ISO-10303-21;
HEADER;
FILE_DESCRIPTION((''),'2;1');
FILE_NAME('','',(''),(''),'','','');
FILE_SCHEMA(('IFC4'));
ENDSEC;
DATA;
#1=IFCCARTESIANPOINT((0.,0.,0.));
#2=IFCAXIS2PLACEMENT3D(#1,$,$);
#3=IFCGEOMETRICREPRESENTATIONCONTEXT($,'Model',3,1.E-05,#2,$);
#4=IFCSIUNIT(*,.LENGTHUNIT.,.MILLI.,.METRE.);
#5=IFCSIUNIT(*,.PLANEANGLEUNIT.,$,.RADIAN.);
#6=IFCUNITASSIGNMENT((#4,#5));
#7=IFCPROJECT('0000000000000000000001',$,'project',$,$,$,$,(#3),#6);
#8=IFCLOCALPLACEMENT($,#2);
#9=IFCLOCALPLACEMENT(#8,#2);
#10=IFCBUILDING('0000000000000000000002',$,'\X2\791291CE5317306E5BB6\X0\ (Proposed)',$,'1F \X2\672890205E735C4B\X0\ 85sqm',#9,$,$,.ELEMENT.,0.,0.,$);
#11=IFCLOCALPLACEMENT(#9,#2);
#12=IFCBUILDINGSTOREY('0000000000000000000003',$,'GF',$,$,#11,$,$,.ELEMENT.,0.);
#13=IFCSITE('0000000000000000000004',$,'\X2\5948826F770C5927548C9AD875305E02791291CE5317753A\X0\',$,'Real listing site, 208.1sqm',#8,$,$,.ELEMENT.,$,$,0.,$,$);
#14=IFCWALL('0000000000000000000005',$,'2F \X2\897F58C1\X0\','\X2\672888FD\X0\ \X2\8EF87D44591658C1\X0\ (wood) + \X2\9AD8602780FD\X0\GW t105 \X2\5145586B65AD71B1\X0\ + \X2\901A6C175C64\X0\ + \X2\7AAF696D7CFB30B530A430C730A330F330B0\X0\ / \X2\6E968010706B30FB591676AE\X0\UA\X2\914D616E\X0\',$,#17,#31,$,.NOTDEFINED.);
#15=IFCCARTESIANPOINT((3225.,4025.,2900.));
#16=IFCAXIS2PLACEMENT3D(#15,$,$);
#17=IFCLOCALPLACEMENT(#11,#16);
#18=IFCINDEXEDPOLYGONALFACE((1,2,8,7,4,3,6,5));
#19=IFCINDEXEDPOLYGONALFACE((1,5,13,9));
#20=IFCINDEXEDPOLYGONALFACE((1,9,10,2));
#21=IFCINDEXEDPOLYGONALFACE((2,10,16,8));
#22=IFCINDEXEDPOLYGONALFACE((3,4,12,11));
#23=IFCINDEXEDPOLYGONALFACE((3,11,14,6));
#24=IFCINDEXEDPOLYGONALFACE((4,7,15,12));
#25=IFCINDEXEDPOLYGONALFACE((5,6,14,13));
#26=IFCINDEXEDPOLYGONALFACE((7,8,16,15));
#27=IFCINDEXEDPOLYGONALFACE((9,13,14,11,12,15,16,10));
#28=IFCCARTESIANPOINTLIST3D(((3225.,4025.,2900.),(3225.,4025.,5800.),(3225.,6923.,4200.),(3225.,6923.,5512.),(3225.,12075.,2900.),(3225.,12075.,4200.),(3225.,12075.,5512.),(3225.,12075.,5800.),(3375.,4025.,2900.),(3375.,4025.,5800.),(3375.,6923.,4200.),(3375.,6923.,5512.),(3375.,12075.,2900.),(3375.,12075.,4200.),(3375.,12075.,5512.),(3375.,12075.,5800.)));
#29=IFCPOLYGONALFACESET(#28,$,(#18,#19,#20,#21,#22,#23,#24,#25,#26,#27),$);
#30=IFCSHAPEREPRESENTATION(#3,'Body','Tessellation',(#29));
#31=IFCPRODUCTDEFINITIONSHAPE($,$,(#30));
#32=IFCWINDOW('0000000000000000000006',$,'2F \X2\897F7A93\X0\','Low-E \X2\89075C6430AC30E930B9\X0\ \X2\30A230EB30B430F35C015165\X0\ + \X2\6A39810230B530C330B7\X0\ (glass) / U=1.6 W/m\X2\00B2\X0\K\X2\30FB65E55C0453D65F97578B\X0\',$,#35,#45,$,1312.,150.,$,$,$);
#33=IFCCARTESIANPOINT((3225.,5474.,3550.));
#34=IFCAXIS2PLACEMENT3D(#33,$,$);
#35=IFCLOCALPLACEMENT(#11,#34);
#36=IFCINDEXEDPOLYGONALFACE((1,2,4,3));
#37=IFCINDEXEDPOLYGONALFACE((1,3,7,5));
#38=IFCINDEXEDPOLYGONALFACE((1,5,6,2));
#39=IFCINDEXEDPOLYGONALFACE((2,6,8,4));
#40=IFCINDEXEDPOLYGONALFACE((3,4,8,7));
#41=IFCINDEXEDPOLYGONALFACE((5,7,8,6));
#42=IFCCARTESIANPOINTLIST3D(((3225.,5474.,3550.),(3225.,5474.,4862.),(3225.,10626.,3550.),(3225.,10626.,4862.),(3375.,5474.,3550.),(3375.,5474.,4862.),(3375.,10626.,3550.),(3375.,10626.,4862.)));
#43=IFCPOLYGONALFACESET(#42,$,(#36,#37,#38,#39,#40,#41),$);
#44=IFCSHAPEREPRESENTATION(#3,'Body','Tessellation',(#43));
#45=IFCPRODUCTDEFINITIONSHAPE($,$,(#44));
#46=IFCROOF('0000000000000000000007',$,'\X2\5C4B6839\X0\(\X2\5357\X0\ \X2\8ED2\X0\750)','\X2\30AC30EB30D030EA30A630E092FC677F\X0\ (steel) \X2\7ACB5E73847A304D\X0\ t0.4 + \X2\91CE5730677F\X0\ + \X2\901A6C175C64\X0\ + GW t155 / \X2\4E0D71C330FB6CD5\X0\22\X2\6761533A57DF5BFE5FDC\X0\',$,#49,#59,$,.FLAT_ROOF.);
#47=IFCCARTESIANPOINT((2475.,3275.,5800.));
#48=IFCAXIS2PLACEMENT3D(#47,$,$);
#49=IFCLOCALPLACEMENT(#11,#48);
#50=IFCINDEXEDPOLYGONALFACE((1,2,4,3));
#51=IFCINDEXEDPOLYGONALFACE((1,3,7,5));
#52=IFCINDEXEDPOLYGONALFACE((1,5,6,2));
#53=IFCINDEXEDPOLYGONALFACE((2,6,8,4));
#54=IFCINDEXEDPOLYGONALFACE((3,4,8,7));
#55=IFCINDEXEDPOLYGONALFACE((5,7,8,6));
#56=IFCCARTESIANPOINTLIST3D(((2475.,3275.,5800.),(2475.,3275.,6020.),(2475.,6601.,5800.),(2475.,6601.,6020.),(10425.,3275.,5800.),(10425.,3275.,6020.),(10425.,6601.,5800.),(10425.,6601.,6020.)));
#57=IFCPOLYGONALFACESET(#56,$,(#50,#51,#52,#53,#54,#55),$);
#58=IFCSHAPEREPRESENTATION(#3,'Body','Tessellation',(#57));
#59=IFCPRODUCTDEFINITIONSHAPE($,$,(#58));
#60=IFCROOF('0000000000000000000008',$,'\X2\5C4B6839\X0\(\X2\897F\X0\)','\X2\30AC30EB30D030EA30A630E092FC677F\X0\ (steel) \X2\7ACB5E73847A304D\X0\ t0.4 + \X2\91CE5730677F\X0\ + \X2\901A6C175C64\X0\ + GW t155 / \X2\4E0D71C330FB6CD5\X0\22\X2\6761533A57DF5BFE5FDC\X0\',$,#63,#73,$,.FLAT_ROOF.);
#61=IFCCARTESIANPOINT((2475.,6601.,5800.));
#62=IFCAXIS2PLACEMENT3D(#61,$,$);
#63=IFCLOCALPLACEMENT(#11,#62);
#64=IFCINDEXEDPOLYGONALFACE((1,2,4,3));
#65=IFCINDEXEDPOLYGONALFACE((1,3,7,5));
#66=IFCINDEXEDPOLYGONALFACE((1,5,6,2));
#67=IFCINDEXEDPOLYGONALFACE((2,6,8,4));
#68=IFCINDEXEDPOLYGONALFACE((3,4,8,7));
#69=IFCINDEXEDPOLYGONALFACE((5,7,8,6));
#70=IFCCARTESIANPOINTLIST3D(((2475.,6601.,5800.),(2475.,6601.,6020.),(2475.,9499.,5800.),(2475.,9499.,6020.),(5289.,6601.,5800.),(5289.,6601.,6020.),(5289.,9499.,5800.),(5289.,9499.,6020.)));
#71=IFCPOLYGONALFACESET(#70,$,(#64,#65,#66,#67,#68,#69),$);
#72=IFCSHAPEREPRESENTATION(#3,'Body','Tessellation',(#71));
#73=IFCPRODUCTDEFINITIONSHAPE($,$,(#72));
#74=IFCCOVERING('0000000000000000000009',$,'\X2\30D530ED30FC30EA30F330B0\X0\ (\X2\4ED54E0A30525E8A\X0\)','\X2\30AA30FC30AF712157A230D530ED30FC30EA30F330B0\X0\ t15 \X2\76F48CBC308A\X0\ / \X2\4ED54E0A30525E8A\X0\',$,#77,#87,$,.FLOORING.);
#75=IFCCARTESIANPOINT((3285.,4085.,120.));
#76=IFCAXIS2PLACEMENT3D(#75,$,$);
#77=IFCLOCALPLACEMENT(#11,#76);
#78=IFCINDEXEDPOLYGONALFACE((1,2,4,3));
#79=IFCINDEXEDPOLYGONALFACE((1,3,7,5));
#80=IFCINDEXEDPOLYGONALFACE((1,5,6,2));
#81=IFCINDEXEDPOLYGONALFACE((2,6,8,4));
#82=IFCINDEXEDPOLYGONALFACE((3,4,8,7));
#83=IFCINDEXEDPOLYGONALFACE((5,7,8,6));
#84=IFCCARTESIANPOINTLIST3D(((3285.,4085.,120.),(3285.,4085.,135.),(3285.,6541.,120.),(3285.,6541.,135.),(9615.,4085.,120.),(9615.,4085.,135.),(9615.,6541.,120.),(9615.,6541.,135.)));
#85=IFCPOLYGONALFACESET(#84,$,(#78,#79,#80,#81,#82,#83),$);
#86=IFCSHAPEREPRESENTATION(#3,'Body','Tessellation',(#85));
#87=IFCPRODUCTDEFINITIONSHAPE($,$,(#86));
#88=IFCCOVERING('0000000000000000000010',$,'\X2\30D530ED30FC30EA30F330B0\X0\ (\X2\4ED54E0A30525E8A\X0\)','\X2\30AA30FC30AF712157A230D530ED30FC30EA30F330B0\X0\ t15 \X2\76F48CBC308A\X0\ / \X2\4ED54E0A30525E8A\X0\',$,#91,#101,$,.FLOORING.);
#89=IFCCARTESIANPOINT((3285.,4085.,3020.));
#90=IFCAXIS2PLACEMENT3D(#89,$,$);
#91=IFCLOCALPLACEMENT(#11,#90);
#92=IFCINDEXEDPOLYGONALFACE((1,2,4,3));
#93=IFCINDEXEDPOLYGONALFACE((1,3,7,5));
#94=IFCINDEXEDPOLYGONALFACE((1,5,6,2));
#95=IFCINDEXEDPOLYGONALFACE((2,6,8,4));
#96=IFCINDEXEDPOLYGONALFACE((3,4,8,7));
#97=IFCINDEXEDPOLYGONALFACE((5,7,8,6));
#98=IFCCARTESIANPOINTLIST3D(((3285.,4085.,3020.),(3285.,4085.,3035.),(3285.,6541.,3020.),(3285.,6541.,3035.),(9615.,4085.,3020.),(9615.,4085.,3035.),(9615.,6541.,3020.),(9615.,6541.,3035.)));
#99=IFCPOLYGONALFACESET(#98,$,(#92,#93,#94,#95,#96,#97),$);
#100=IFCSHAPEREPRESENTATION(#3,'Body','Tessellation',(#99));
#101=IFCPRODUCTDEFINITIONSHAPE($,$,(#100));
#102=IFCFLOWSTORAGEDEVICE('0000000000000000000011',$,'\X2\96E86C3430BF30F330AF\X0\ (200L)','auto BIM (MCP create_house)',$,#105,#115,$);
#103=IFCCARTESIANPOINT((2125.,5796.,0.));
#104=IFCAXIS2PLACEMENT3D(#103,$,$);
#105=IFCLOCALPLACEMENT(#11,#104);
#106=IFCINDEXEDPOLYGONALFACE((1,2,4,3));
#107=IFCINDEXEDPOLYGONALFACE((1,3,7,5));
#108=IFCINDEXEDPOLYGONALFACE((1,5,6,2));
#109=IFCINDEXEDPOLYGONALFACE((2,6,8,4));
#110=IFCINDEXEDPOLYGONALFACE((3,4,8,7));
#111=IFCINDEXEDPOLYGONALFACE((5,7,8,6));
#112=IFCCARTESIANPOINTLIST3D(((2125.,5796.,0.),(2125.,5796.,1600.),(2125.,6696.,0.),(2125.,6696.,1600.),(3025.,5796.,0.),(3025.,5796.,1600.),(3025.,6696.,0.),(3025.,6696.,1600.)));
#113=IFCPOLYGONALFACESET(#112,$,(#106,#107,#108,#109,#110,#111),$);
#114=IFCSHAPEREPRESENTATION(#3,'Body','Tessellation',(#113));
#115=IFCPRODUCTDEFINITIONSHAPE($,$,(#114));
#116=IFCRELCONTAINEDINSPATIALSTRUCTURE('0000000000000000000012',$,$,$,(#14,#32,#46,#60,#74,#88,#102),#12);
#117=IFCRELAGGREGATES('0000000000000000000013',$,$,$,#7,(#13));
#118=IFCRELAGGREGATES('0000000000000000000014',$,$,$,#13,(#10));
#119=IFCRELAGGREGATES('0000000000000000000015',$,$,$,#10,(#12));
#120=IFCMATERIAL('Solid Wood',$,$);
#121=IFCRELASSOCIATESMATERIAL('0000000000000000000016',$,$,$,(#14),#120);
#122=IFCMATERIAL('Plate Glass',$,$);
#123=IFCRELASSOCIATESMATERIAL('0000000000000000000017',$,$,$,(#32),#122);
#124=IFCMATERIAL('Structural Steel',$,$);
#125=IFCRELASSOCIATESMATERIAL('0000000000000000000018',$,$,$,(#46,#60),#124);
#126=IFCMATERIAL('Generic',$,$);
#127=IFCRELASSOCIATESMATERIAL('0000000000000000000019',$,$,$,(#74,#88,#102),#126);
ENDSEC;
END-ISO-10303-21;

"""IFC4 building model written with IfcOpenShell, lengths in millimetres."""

from ifc_helpers import new_model, si_unit, frame, frame_2d, origin, place, context, project, spatial, rectangle, extrude, material, element, fill, save


model = new_model("IFC4")

# Units and contexts
model_context = context("Model", 3, precision=1e-05, world=origin())
ifc_project = project(units=[si_unit("LENGTHUNIT", "METRE", prefix="MILLI"), si_unit("PLANEANGLEUNIT", "RADIAN")], contexts=[model_context])

# Site, building, storey
site_placement = place(None, origin())
site = spatial("IfcSite", under=ifc_project, at=site_placement, Name="奈良県大和高田市礒野北町", ObjectType="Real listing site, 208.1sqm", CompositionType="ELEMENT", RefElevation=0.0)
building_placement = place(site_placement, origin())
building = spatial("IfcBuilding", under=site, at=building_placement, Name="礒野北の家 (Proposed)", ObjectType="1F 木造平屋 85sqm", CompositionType="ELEMENT", ElevationOfRefHeight=0.0, ElevationOfTerrain=0.0)
storey_placement = place(building_placement, origin())
storey = spatial("IfcBuildingStorey", under=building, at=storey_placement, Name="GF", CompositionType="ELEMENT", Elevation=0.0)

# Shared definitions
ifc_material_1 = material(Name="Solid Wood")
ifc_material_2 = material(Name="Generic")

# Shared definitions
ifc_material_3 = material(Name="Plate Glass")

# Wall, opening, window
wall_1_placement = place(storey_placement, frame((3225.0, 4025.0, 2900.0)))
wall_1 = element("IfcWall", 1, at=wall_1_placement, inside=storey, material=ifc_material_1, Name="2F 西壁", Description="木製 軸組外壁 (wood) + 高性能GW t105 充填断熱 + 通気層 + 窯業系サイディング / 準耐火・外皮UA配慮", PredefinedType="NOTDEFINED", context=model_context, shape_type="SweptSolid", body=[
    extrude(rectangle(XDim=150.0, YDim=8050.0, at=frame_2d((75.0, 4025.0))), frame((3225.0, 4025.0, 2900.0)), (0.0, 0.0, 1.0), 2900.0),
])
opening_1_placement = place(storey_placement, frame((3225.0, 5474.0, 3550.0)))
opening_1 = element("IfcOpeningElement", 2, at=opening_1_placement, cuts=wall_1, PredefinedType="NOTDEFINED", context=model_context, shape_type="SweptSolid", body=[
    extrude(rectangle(XDim=150.0, YDim=5152.0, at=frame_2d((75.0, 2576.0))), frame((3225.0, 5474.0, 3550.0)), (0.0, 0.0, 1.0), 1312.0),
])
window_1_placement = place(storey_placement, frame((3225.0, 5474.0, 3550.0)))
window_1 = element("IfcWindow", 3, at=window_1_placement, inside=storey, material=ifc_material_3, Name="2F 西窓", Description="Low-E 複層ガラス アルゴン封入 + 樹脂サッシ (glass) / U=1.6 W/m²K・日射取得型", OverallHeight=1312.0, OverallWidth=150.0, context=model_context, shape_type="SweptSolid", body=[
    extrude(rectangle(XDim=150.0, YDim=5152.0, at=frame_2d((75.0, 2576.0))), frame((3225.0, 5474.0, 3550.0)), (0.0, 0.0, 1.0), 1312.0),
])
fill(opening_1, window_1)

# Roofs
ifc_material_4 = material(Name="Structural Steel")
roof_1_placement = place(storey_placement, frame((2475.0, 3275.0, 5800.0)))
element("IfcRoof", 4, at=roof_1_placement, inside=storey, material=ifc_material_4, Name="屋根(南 軒750)", Description="ガルバリウム鋼板 (steel) 立平葺き t0.4 + 野地板 + 通気層 + GW t155 / 不燃・法22条区域対応", PredefinedType="FLAT_ROOF", context=model_context, shape_type="SweptSolid", body=[
    extrude(rectangle(XDim=7950.0, YDim=3326.0, at=frame_2d((3975.0, 1663.0))), frame((2475.0, 3275.0, 5800.0)), (0.0, 0.0, 1.0), 220.0),
])
roof_2_placement = place(storey_placement, frame((2475.0, 6601.0, 5800.0)))
element("IfcRoof", 5, at=roof_2_placement, inside=storey, material=ifc_material_4, Name="屋根(西)", Description="ガルバリウム鋼板 (steel) 立平葺き t0.4 + 野地板 + 通気層 + GW t155 / 不燃・法22条区域対応", PredefinedType="FLAT_ROOF", context=model_context, shape_type="SweptSolid", body=[
    extrude(rectangle(XDim=2814.0, YDim=2898.0, at=frame_2d((1407.0, 1449.0))), frame((2475.0, 6601.0, 5800.0)), (0.0, 0.0, 1.0), 220.0),
])

# Coverings
covering_1_placement = place(storey_placement, frame((3285.0, 4085.0, 120.0)))
element("IfcCovering", 6, at=covering_1_placement, inside=storey, material=ifc_material_2, Name="フローリング (仕上げ床)", Description="オーク無垢フローリング t15 直貼り / 仕上げ床", PredefinedType="FLOORING", context=model_context, shape_type="SweptSolid", body=[
    extrude(rectangle(XDim=6330.0, YDim=2456.0, at=frame_2d((3165.0, 1228.0))), frame((3285.0, 4085.0, 120.0)), (0.0, 0.0, 1.0), 15.0),
])
covering_2_placement = place(storey_placement, frame((3285.0, 4085.0, 3020.0)))
element("IfcCovering", 7, at=covering_2_placement, inside=storey, material=ifc_material_2, Name="フローリング (仕上げ床)", Description="オーク無垢フローリング t15 直貼り / 仕上げ床", PredefinedType="FLOORING", context=model_context, shape_type="SweptSolid", body=[
    extrude(rectangle(XDim=6330.0, YDim=2456.0, at=frame_2d((3165.0, 1228.0))), frame((3285.0, 4085.0, 3020.0)), (0.0, 0.0, 1.0), 15.0),
])

# Flow storage device
flow_storage_device_placement = place(storey_placement, frame((2125.0, 5796.0, 0.0)))
element("IfcFlowStorageDevice", 8, at=flow_storage_device_placement, inside=storey, material=ifc_material_2, Name="雨水タンク (200L)", Description="auto BIM (MCP create_house)", context=model_context, shape_type="SweptSolid", body=[
    extrude(rectangle(XDim=900.0, YDim=900.0, at=frame_2d((450.0, 450.0))), frame((2125.0, 5796.0, 0.0)), (0.0, 0.0, 1.0), 1600.0),
])

save(model, "model.ifc")
